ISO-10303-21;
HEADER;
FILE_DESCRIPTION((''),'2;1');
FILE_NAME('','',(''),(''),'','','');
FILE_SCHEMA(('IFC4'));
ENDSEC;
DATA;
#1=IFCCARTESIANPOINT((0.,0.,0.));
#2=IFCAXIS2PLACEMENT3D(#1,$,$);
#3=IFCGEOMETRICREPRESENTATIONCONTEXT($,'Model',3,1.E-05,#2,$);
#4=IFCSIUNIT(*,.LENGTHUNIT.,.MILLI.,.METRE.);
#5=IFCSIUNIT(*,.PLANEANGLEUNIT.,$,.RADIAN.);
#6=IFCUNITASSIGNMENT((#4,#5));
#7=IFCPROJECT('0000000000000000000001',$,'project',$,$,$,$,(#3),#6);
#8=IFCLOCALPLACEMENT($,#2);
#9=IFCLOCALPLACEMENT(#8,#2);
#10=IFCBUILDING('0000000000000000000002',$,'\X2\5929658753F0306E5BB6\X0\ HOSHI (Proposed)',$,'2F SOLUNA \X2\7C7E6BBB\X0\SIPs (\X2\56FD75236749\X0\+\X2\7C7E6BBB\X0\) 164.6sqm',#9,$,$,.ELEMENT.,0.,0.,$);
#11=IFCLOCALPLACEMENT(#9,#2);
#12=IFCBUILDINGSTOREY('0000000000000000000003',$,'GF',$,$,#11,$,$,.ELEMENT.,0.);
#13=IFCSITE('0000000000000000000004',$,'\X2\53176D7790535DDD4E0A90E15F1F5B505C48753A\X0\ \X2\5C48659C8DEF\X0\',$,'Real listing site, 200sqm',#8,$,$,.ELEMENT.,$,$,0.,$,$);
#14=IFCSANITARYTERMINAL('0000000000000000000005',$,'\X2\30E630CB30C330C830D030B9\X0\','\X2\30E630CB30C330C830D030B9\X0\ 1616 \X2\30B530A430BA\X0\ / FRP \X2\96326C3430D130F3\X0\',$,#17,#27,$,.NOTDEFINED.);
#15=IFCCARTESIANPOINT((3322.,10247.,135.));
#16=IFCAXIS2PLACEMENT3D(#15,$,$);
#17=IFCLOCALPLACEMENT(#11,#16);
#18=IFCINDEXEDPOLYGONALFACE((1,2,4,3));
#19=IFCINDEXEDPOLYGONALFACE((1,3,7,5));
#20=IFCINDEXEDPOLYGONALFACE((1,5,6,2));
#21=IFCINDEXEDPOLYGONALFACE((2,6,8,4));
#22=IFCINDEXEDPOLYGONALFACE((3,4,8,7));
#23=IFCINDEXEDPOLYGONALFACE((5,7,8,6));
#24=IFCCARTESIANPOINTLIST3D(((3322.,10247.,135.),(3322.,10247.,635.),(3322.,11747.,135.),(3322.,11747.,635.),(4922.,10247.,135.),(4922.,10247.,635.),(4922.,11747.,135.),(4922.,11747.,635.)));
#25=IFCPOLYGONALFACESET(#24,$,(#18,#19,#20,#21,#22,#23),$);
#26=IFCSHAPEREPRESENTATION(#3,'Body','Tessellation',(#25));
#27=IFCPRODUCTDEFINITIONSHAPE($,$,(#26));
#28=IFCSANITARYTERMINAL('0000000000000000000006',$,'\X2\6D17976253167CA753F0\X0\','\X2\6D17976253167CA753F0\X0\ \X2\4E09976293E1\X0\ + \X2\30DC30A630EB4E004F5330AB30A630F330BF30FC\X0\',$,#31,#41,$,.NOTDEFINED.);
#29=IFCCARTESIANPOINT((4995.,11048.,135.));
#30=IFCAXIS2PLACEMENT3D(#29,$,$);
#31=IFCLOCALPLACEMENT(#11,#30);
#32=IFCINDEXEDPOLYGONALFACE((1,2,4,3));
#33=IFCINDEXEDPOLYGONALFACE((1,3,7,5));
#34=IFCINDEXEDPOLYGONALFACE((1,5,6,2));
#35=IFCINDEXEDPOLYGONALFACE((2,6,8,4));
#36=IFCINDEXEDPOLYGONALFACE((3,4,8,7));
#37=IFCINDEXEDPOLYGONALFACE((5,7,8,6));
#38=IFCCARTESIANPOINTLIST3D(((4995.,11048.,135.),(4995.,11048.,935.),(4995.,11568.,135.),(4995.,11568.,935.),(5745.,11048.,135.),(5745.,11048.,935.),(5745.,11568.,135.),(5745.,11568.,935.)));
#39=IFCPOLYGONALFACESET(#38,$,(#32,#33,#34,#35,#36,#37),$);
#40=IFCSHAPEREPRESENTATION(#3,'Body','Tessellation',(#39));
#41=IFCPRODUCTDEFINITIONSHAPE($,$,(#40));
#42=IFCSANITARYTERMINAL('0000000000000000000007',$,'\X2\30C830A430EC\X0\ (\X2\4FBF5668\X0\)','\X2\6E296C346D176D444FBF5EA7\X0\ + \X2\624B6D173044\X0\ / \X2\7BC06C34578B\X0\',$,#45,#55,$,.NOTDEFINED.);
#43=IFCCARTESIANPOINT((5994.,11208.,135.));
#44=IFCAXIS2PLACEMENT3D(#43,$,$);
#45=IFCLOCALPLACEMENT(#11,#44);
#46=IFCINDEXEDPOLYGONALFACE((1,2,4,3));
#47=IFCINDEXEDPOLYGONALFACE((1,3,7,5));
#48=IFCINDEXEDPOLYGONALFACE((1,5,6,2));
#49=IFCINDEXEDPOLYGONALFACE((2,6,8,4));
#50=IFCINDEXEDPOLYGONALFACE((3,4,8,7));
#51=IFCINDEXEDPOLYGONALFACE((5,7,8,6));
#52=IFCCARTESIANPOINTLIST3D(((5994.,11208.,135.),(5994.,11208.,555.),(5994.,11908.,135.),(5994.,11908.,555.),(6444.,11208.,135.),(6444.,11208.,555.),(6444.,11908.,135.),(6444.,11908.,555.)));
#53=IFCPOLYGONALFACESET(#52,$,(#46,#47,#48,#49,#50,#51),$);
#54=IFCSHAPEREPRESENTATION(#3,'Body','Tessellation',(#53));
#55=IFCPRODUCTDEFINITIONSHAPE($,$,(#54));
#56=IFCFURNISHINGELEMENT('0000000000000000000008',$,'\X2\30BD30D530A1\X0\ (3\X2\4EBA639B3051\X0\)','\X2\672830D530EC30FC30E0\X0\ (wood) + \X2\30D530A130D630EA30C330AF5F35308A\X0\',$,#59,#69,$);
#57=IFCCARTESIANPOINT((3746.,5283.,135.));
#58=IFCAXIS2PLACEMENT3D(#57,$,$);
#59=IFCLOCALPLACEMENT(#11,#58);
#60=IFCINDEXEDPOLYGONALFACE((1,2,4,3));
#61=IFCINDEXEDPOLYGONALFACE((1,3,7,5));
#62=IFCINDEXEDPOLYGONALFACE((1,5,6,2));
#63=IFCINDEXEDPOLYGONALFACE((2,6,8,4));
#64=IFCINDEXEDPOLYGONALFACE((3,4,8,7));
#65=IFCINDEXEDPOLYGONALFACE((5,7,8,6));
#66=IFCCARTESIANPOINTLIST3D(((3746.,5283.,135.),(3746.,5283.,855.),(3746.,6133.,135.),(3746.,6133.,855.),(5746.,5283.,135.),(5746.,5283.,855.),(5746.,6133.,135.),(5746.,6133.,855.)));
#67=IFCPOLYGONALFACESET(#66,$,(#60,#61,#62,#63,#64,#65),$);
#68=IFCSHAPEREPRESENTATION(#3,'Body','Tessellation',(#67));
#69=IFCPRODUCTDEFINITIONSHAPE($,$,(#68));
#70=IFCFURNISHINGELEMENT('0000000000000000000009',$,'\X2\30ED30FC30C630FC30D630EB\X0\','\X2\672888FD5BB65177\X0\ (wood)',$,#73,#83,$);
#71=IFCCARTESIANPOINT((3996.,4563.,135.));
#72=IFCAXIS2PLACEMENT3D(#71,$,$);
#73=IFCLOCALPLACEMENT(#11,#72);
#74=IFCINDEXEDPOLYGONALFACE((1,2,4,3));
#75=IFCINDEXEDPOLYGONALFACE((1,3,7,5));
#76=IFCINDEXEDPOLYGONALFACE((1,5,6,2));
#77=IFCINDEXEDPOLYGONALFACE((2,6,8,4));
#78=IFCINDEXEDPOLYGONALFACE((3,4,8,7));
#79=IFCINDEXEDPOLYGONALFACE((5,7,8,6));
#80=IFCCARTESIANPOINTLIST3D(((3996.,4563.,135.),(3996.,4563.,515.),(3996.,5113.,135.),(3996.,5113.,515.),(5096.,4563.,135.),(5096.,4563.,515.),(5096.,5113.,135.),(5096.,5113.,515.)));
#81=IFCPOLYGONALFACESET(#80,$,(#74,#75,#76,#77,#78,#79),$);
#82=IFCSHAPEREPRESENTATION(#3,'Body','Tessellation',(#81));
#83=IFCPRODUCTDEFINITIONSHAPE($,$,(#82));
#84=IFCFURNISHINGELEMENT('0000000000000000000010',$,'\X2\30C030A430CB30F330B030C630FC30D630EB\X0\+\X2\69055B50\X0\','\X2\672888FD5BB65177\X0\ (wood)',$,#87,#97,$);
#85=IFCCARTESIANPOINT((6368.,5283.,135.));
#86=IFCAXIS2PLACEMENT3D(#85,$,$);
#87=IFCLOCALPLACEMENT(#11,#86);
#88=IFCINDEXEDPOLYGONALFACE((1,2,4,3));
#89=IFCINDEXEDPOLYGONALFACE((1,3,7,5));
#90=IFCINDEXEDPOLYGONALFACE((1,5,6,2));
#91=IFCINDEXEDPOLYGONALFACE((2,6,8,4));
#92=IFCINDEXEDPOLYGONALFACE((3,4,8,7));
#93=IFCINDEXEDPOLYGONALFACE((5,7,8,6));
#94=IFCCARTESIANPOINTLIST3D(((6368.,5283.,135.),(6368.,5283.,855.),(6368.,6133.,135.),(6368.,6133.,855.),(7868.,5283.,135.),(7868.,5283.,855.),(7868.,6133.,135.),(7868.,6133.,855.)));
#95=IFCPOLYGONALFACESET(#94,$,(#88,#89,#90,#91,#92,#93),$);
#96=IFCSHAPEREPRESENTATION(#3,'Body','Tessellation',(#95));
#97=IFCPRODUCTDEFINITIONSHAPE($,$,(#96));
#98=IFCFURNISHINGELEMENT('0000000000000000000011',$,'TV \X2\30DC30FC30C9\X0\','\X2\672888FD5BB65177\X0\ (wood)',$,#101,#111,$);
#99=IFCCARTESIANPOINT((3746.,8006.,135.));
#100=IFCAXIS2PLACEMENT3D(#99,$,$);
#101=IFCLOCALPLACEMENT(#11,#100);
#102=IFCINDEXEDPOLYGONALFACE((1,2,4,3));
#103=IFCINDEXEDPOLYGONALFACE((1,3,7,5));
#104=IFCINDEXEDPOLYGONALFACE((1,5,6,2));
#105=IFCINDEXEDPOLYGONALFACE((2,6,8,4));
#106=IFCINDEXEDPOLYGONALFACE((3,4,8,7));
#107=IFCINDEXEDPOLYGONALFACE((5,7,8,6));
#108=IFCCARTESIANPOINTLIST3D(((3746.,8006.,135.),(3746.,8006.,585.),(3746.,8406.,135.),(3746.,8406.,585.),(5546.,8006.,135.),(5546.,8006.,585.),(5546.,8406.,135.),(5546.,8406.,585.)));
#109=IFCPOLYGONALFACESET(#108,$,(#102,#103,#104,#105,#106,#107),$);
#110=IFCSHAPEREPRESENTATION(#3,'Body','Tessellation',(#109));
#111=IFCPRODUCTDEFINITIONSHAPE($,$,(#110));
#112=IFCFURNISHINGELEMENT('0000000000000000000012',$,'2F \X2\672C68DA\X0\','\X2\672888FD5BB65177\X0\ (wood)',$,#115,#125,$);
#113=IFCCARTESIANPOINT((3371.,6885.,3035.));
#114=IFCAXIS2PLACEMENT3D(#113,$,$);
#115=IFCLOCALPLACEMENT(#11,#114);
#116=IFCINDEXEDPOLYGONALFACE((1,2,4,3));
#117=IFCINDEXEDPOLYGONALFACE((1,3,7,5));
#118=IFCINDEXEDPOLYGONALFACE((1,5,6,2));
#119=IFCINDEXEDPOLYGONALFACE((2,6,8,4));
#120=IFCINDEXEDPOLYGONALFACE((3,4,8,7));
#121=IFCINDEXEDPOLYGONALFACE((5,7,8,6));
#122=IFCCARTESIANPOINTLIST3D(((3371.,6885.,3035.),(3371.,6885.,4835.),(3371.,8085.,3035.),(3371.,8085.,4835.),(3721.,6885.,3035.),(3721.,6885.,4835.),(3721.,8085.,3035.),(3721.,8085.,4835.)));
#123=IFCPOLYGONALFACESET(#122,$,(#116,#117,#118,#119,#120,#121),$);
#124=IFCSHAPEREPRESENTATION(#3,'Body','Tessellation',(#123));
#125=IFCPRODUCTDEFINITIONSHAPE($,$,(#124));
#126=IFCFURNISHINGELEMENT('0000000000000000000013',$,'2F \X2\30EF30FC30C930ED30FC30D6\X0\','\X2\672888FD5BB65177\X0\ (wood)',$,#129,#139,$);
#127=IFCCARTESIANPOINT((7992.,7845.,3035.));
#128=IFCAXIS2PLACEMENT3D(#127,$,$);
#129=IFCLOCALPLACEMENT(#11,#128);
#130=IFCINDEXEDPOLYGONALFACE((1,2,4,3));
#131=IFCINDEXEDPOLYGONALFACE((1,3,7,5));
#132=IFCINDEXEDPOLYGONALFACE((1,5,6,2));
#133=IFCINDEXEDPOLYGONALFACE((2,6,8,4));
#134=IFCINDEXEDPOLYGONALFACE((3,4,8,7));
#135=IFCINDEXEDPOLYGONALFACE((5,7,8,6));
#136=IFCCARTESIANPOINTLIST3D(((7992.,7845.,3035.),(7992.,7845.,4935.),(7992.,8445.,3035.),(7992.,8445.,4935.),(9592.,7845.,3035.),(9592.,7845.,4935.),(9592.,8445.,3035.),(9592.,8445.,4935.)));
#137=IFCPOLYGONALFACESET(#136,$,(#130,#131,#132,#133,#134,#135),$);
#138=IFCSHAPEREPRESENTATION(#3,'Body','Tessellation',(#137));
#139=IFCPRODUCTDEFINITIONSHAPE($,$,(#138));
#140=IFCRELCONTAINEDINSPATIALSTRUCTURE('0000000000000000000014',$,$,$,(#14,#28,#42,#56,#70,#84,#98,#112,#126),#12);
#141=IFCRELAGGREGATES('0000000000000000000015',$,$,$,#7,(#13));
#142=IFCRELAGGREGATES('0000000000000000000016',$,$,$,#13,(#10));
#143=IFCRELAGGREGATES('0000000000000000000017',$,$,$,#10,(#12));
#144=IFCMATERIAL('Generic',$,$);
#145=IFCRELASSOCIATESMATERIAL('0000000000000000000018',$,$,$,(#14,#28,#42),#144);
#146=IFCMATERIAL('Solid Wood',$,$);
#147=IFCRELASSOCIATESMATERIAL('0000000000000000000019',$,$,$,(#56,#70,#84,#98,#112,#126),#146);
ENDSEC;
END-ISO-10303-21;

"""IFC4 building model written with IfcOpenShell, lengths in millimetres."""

from ifc_helpers import new_model, si_unit, frame, frame_2d, origin, place, context, project, spatial, rectangle, extrude, material, element, save


model = new_model("IFC4")

# Units and contexts
model_context = context("Model", 3, precision=1e-05, world=origin())
ifc_project = project(units=[si_unit("LENGTHUNIT", "METRE", prefix="MILLI"), si_unit("PLANEANGLEUNIT", "RADIAN")], contexts=[model_context])

# Site, building, storey
site_placement = place(None, origin())
site = spatial("IfcSite", under=ifc_project, at=site_placement, Name="北海道川上郡弟子屈町 屈斜路", ObjectType="Real listing site, 200sqm", CompositionType="ELEMENT", RefElevation=0.0)
building_placement = place(site_placement, origin())
building = spatial("IfcBuilding", under=site, at=building_placement, Name="天文台の家 HOSHI (Proposed)", ObjectType="2F SOLUNA 籾殻SIPs (国産杉+籾殻) 164.6sqm", CompositionType="ELEMENT", ElevationOfRefHeight=0.0, ElevationOfTerrain=0.0)
storey_placement = place(building_placement, origin())
storey = spatial("IfcBuildingStorey", under=building, at=storey_placement, Name="GF", CompositionType="ELEMENT", Elevation=0.0)

# Shared definitions
ifc_material_1 = material(Name="Generic")

# Shared definitions
ifc_material_2 = material(Name="Solid Wood")

# Sanitary terminals
sanitary_terminal_1_placement = place(storey_placement, frame((3322.0, 10247.0, 135.0)))
element("IfcSanitaryTerminal", 1, at=sanitary_terminal_1_placement, inside=storey, material=ifc_material_1, Name="ユニットバス", Description="ユニットバス 1616 サイズ / FRP 防水パン", PredefinedType="NOTDEFINED", context=model_context, shape_type="SweptSolid", body=[
    extrude(rectangle(XDim=1600.0, YDim=1500.0, at=frame_2d((800.0, 750.0))), frame((3322.0, 10247.0, 135.0)), (0.0, 0.0, 1.0), 500.0),
])
sanitary_terminal_2_placement = place(storey_placement, frame((4995.0, 11048.0, 135.0)))
element("IfcSanitaryTerminal", 2, at=sanitary_terminal_2_placement, inside=storey, material=ifc_material_1, Name="洗面化粧台", Description="洗面化粧台 三面鏡 + ボウル一体カウンター", PredefinedType="NOTDEFINED", context=model_context, shape_type="SweptSolid", body=[
    extrude(rectangle(XDim=750.0, YDim=520.0, at=frame_2d((375.0, 260.0))), frame((4995.0, 11048.0, 135.0)), (0.0, 0.0, 1.0), 800.0),
])
sanitary_terminal_3_placement = place(storey_placement, frame((5994.0, 11208.0, 135.0)))
element("IfcSanitaryTerminal", 3, at=sanitary_terminal_3_placement, inside=storey, material=ifc_material_1, Name="トイレ (便器)", Description="温水洗浄便座 + 手洗い / 節水型", PredefinedType="NOTDEFINED", context=model_context, shape_type="SweptSolid", body=[
    extrude(rectangle(XDim=450.0, YDim=700.0, at=frame_2d((225.0, 350.0))), frame((5994.0, 11208.0, 135.0)), (0.0, 0.0, 1.0), 420.0),
])

# Furnishing elements
furnishing_1_placement = place(storey_placement, frame((3746.0, 5283.0, 135.0)))
element("IfcFurnishingElement", 4, at=furnishing_1_placement, inside=storey, material=ifc_material_2, Name="ソファ (3人掛け)", Description="木フレーム (wood) + ファブリック張り", context=model_context, shape_type="SweptSolid", body=[
    extrude(rectangle(XDim=2000.0, YDim=850.0, at=frame_2d((1000.0, 425.0))), frame((3746.0, 5283.0, 135.0)), (0.0, 0.0, 1.0), 720.0),
])
furnishing_2_placement = place(storey_placement, frame((3996.0, 4563.0, 135.0)))
element("IfcFurnishingElement", 5, at=furnishing_2_placement, inside=storey, material=ifc_material_2, Name="ローテーブル", Description="木製家具 (wood)", context=model_context, shape_type="SweptSolid", body=[
    extrude(rectangle(XDim=1100.0, YDim=550.0, at=frame_2d((550.0, 275.0))), frame((3996.0, 4563.0, 135.0)), (0.0, 0.0, 1.0), 380.0),
])
furnishing_3_placement = place(storey_placement, frame((6368.0, 5283.0, 135.0)))
element("IfcFurnishingElement", 6, at=furnishing_3_placement, inside=storey, material=ifc_material_2, Name="ダイニングテーブル+椅子", Description="木製家具 (wood)", context=model_context, shape_type="SweptSolid", body=[
    extrude(rectangle(XDim=1500.0, YDim=850.0, at=frame_2d((750.0, 425.0))), frame((6368.0, 5283.0, 135.0)), (0.0, 0.0, 1.0), 720.0),
])
furnishing_4_placement = place(storey_placement, frame((3746.0, 8006.0, 135.0)))
element("IfcFurnishingElement", 7, at=furnishing_4_placement, inside=storey, material=ifc_material_2, Name="TV ボード", Description="木製家具 (wood)", context=model_context, shape_type="SweptSolid", body=[
    extrude(rectangle(XDim=1800.0, YDim=400.0, at=frame_2d((900.0, 200.0))), frame((3746.0, 8006.0, 135.0)), (0.0, 0.0, 1.0), 450.0),
])
furnishing_5_placement = place(storey_placement, frame((3371.0, 6885.0, 3035.0)))
element("IfcFurnishingElement", 8, at=furnishing_5_placement, inside=storey, material=ifc_material_2, Name="2F 本棚", Description="木製家具 (wood)", context=model_context, shape_type="SweptSolid", body=[
    extrude(rectangle(XDim=350.0, YDim=1200.0, at=frame_2d((175.0, 600.0))), frame((3371.0, 6885.0, 3035.0)), (0.0, 0.0, 1.0), 1800.0),
])
furnishing_6_placement = place(storey_placement, frame((7992.0, 7845.0, 3035.0)))
element("IfcFurnishingElement", 9, at=furnishing_6_placement, inside=storey, material=ifc_material_2, Name="2F ワードローブ", Description="木製家具 (wood)", context=model_context, shape_type="SweptSolid", body=[
    extrude(rectangle(XDim=1600.0, YDim=600.0, at=frame_2d((800.0, 300.0))), frame((7992.0, 7845.0, 3035.0)), (0.0, 0.0, 1.0), 1900.0),
])

save(model, "model.ifc")
